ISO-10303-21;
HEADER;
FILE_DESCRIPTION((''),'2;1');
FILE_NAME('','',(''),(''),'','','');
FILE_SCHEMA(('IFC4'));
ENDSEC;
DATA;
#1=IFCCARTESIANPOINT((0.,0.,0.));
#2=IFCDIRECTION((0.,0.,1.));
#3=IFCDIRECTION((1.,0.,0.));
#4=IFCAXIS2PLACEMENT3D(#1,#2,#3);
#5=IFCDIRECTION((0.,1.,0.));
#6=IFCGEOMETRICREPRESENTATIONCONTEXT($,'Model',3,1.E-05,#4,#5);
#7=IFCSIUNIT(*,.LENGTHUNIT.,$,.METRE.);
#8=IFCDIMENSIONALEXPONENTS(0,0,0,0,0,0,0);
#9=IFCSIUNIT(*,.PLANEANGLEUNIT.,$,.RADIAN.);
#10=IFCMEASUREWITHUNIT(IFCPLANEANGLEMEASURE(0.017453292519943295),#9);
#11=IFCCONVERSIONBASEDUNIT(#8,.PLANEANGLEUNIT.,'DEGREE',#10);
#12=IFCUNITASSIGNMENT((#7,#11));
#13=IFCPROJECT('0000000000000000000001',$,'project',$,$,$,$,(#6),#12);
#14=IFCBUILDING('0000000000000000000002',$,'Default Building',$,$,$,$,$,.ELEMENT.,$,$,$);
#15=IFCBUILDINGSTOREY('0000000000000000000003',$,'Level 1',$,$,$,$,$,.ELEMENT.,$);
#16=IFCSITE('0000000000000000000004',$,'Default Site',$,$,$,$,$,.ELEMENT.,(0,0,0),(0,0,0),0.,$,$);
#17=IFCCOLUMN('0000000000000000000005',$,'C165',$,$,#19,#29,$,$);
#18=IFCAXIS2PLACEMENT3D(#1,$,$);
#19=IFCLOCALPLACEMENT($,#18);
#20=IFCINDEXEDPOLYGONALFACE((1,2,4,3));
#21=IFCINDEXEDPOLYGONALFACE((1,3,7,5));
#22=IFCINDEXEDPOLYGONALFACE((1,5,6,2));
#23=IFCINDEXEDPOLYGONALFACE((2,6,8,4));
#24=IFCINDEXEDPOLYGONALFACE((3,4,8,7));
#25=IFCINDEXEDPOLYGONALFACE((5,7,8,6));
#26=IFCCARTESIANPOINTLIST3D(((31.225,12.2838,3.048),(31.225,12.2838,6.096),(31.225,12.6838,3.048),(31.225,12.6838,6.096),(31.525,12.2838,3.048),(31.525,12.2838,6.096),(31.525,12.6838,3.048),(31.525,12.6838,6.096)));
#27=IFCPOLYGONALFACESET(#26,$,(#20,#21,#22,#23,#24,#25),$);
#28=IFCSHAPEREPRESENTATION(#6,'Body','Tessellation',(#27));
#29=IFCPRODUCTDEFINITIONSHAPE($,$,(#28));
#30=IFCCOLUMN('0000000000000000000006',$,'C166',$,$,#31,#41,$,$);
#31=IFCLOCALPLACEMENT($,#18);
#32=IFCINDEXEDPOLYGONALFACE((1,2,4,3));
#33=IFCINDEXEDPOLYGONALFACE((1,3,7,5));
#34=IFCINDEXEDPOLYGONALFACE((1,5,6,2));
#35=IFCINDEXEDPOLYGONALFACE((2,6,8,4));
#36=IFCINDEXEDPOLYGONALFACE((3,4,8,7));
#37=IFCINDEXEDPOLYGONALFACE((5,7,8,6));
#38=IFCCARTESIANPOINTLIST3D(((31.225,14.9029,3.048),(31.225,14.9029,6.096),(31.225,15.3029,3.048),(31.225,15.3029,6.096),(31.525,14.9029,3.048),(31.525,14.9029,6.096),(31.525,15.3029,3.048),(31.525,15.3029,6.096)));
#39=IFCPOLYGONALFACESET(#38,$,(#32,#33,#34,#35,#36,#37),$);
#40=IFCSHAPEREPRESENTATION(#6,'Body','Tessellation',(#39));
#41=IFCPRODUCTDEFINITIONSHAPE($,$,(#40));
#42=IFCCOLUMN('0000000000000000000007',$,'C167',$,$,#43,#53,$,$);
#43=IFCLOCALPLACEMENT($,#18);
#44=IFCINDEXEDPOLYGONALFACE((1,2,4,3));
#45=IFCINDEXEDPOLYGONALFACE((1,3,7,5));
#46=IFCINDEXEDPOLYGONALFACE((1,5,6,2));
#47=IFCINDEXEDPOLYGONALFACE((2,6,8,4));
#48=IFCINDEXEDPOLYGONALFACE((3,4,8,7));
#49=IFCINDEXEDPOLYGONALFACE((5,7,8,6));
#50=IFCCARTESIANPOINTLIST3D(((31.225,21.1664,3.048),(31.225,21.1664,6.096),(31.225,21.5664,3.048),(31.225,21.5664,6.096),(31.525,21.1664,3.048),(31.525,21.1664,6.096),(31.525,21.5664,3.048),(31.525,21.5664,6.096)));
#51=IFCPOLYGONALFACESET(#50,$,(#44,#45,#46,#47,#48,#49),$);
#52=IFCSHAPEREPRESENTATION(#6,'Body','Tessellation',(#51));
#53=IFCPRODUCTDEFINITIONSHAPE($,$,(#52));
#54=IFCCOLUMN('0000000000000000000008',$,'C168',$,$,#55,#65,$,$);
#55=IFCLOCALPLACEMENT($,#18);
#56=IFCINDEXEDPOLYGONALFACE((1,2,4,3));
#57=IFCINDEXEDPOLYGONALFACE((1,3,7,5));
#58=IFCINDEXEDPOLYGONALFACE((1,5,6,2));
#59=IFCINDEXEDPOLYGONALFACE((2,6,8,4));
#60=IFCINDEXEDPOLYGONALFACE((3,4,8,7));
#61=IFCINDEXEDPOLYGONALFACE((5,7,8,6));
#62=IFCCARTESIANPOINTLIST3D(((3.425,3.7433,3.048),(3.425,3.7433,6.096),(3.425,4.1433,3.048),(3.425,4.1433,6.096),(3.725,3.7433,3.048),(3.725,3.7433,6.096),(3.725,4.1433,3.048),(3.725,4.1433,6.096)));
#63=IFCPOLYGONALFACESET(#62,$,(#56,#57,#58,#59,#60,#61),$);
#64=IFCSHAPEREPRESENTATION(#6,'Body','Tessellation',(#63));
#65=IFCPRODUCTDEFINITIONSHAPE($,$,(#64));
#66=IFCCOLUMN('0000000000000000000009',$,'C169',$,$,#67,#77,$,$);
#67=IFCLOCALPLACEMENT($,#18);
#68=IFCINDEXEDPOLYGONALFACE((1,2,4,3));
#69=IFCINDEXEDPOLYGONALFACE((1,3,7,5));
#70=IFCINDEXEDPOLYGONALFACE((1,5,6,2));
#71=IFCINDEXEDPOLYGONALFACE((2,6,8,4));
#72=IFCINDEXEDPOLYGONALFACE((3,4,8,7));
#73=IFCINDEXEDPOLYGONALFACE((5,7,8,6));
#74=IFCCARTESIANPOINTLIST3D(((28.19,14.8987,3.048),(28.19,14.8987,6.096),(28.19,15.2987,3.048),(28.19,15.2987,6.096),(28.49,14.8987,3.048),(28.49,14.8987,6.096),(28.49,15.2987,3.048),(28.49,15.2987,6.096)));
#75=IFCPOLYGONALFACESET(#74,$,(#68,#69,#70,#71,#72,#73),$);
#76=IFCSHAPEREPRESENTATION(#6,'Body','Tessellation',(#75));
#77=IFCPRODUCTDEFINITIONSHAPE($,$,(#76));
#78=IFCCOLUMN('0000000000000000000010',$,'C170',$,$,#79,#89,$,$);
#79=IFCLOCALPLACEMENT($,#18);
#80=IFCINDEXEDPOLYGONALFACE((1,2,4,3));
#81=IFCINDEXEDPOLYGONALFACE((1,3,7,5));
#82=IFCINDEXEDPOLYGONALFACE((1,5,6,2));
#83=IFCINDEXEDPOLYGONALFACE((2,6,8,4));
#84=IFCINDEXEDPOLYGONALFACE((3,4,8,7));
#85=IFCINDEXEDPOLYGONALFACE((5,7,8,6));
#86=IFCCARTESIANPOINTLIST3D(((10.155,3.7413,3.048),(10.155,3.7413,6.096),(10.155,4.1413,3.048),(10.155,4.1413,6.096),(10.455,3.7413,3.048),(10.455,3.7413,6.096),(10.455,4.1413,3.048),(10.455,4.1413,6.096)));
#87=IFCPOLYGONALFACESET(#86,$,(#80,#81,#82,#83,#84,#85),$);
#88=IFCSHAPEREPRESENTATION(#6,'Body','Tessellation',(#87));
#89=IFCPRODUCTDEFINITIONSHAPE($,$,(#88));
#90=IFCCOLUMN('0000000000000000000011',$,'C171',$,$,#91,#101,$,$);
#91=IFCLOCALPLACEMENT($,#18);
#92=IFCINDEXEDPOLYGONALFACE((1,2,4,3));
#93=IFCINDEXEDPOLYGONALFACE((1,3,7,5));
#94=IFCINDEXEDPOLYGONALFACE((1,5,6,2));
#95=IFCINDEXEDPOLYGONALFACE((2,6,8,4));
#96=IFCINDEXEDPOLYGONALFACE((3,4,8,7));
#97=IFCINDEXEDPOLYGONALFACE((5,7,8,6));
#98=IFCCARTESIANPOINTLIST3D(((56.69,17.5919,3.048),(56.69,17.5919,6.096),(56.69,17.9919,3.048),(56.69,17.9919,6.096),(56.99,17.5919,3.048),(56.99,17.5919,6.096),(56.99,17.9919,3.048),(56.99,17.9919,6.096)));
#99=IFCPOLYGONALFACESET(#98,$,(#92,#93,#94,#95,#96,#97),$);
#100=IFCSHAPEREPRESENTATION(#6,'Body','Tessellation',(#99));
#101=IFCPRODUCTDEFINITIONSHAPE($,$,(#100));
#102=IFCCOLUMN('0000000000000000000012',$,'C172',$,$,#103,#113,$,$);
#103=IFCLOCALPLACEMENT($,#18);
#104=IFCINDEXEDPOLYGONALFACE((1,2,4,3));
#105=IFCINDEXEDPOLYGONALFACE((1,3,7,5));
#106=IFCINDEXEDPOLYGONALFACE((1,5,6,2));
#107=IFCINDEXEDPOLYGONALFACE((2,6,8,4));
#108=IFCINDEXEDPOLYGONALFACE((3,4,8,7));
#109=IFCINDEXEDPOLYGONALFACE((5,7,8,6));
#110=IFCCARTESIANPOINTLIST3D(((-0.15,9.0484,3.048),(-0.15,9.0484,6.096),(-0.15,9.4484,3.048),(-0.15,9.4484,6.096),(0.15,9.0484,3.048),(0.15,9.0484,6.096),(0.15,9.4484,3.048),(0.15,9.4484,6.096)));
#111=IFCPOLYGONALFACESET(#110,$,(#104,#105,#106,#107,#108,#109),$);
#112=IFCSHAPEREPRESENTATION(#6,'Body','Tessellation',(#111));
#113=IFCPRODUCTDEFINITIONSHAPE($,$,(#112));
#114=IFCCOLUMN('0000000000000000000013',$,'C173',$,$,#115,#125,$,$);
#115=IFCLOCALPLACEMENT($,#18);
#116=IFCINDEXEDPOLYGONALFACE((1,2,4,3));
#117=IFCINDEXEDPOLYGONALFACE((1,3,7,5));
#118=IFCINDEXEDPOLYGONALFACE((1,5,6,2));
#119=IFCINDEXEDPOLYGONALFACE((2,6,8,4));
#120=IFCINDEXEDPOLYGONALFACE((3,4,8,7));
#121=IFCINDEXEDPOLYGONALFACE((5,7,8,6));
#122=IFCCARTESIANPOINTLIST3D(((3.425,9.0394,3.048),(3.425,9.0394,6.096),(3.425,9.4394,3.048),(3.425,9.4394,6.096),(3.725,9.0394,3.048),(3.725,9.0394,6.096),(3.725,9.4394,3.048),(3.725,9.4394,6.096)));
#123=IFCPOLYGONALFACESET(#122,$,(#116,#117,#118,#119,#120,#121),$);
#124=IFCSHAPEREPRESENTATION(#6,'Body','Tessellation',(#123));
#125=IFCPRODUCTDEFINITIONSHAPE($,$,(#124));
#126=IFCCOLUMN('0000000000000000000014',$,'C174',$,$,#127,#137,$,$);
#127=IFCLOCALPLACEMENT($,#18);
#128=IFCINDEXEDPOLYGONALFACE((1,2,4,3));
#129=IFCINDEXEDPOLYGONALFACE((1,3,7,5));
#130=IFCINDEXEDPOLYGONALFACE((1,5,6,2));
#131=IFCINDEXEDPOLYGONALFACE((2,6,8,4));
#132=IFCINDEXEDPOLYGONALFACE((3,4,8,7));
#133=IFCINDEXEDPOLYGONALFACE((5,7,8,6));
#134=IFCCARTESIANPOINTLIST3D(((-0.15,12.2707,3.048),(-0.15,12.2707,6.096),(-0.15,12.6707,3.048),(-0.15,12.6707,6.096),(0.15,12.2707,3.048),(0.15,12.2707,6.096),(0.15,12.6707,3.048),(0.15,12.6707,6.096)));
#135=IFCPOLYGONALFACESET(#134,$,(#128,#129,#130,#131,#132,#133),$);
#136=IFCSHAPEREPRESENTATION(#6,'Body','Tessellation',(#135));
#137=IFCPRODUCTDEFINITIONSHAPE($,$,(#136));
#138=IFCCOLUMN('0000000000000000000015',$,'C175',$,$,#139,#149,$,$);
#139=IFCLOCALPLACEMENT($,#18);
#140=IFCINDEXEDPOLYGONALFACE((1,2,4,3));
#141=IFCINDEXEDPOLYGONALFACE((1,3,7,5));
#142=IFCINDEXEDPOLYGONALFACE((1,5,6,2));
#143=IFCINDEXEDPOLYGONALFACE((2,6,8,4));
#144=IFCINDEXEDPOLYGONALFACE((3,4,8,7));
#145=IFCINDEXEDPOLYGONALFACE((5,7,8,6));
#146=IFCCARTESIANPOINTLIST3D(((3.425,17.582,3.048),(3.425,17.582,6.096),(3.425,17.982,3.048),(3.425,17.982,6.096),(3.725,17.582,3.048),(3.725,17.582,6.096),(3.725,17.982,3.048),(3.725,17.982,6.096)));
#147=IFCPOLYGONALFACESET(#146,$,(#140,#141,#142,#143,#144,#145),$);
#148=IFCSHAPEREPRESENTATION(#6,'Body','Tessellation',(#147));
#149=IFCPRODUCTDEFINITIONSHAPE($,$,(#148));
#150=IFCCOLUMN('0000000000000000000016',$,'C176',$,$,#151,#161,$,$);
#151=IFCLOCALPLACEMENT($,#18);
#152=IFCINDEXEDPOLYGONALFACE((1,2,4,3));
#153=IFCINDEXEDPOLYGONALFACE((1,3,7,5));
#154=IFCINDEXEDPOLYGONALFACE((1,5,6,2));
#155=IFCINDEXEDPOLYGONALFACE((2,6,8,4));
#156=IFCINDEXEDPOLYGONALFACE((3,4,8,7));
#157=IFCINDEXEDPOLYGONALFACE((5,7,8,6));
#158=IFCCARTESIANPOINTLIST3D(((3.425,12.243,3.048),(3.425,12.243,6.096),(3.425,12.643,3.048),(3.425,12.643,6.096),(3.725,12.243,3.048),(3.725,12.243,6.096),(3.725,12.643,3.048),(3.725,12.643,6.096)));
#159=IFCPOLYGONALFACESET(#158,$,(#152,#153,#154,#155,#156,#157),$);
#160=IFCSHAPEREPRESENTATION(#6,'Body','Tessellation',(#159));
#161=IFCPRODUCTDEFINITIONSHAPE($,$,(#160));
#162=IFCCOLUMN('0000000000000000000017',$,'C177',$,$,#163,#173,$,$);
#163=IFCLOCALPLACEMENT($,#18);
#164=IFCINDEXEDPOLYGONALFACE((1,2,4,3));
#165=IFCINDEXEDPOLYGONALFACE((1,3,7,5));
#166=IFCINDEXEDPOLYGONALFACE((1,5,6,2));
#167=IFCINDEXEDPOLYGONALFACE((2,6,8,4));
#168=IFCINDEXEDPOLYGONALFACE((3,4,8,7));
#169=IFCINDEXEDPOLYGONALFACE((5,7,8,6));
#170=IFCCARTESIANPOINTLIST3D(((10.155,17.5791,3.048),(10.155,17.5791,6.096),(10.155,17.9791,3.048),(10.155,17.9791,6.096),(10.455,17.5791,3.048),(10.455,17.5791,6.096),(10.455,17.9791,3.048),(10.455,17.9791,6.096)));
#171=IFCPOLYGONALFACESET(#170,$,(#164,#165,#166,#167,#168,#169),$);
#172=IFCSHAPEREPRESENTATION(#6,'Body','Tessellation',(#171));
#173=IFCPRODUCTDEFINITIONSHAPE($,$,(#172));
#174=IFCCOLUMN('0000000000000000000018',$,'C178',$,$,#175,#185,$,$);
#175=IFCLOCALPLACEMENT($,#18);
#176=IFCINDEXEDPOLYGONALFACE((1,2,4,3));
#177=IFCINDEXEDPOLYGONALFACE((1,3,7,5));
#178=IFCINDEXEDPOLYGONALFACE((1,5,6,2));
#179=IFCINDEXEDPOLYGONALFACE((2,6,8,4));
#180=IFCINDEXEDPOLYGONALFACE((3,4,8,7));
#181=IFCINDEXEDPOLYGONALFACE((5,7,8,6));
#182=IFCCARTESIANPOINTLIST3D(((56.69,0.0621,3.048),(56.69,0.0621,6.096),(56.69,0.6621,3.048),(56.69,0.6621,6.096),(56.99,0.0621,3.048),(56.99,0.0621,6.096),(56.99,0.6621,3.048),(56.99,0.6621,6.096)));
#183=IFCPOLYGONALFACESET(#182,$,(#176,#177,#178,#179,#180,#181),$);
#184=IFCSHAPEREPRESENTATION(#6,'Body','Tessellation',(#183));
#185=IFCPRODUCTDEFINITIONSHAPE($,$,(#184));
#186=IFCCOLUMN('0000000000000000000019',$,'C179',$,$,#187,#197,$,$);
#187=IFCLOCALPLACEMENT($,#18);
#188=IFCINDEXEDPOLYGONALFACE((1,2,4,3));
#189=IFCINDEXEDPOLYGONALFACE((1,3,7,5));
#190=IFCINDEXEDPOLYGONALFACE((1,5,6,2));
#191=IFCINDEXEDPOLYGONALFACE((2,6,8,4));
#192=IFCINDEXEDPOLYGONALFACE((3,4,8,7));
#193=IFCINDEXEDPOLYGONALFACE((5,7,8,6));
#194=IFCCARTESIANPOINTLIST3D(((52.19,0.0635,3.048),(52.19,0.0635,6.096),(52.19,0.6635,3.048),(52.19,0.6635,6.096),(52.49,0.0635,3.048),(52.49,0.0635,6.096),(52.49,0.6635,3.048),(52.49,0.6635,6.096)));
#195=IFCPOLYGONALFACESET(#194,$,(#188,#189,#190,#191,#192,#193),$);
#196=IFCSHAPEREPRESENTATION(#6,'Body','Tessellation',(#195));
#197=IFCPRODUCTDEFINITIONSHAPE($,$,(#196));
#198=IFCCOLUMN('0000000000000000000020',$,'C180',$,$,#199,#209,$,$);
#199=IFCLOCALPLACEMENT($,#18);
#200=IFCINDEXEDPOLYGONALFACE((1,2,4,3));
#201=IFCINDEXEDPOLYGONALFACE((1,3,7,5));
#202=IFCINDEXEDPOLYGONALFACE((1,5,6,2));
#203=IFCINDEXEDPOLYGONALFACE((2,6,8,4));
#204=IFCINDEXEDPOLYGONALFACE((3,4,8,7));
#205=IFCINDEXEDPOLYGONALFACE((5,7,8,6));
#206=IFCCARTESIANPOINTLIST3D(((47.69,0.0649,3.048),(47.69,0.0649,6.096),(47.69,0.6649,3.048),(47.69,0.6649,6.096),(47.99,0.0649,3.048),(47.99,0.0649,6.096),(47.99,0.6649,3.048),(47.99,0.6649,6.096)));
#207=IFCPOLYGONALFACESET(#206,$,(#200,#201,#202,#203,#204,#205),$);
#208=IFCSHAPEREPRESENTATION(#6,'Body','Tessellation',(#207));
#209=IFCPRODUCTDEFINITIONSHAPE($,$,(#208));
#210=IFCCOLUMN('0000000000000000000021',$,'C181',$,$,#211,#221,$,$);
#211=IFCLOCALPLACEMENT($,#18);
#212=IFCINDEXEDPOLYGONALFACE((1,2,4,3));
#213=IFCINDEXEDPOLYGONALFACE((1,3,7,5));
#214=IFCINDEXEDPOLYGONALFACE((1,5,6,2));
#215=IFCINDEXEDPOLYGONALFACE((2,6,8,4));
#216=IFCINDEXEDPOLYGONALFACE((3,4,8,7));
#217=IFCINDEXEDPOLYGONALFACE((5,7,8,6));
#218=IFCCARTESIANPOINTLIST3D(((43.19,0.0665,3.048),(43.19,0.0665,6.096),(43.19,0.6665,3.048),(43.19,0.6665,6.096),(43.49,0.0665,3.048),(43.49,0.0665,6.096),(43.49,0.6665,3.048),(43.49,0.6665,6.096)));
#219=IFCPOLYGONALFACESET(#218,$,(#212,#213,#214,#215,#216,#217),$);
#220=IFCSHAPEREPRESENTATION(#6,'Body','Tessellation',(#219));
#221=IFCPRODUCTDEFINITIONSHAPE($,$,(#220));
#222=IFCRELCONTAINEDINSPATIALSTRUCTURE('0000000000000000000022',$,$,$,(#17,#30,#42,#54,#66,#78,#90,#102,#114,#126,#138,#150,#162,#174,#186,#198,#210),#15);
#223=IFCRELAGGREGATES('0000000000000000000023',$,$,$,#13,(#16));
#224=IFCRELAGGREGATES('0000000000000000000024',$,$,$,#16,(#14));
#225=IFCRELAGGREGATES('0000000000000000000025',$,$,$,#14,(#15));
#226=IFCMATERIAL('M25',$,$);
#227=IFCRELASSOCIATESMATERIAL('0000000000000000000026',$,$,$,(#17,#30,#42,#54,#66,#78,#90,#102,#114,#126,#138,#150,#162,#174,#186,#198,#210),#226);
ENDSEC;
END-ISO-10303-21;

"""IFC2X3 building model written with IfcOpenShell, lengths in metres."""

from ifc_helpers import new_model, entity, si_unit, converted_unit, direction, frame, frame_2d, origin_with_axes, place, context, project, spatial, rectangle, extrude, material, element, save


model = new_model("IFC2X3")

# Units and contexts
model_context = context("Model", 3, precision=1e-05, world=origin_with_axes(), true_north=direction((0.0, 1.0, 0.0)))
ifc_project = project(units=[si_unit("LENGTHUNIT", "METRE"), converted_unit("PLANEANGLEUNIT", "DEGREE", entity("IfcPlaneAngleMeasure", 0.017453292519943295), si_unit("PLANEANGLEUNIT", "RADIAN"), dimensions=[0, 0, 0, 0, 0, 0, 0])], contexts=[model_context])

# Site, building, storey
site = spatial("IfcSite", under=ifc_project, Name="Default Site", CompositionType="ELEMENT", RefLatitude=(0, 0, 0), RefLongitude=(0, 0, 0), RefElevation=0.0)
building = spatial("IfcBuilding", under=site, Name="Default Building", CompositionType="ELEMENT")
storey = spatial("IfcBuildingStorey", under=building, Name="Level 1", CompositionType="ELEMENT")

# Columns
ifc_material = material(Name="M25")
placement = place(None, origin_with_axes())
element("IfcColumn", 1, at=placement, inside=storey, material=ifc_material, Name="C165", context=model_context, shape_type="SweptSolid", body=[
    extrude(rectangle(XDim=0.3, YDim=0.4, at=frame_2d((0.0, 0.0), x_axis=(1.0, 0.0, 0.0))), frame((31.375, 12.4838, 3.048), z_axis=(0.0, 0.0, 1.0), x_axis=(1.0, 0.0, 0.0)), (0.0, 0.0, 1.0), 3.048),
])
element("IfcColumn", 2, at=placement, inside=storey, material=ifc_material, Name="C166", context=model_context, shape_type="SweptSolid", body=[
    extrude(rectangle(XDim=0.3, YDim=0.4, at=frame_2d((0.0, 0.0), x_axis=(1.0, 0.0, 0.0))), frame((31.375, 15.1029, 3.048), z_axis=(0.0, 0.0, 1.0), x_axis=(1.0, 0.0, 0.0)), (0.0, 0.0, 1.0), 3.048),
])
element("IfcColumn", 3, at=placement, inside=storey, material=ifc_material, Name="C167", context=model_context, shape_type="SweptSolid", body=[
    extrude(rectangle(XDim=0.3, YDim=0.4, at=frame_2d((0.0, 0.0), x_axis=(1.0, 0.0, 0.0))), frame((31.375, 21.3664, 3.048), z_axis=(0.0, 0.0, 1.0), x_axis=(1.0, 0.0, 0.0)), (0.0, 0.0, 1.0), 3.048),
])
element("IfcColumn", 4, at=placement, inside=storey, material=ifc_material, Name="C168", context=model_context, shape_type="SweptSolid", body=[
    extrude(rectangle(XDim=0.3, YDim=0.4, at=frame_2d((0.0, 0.0), x_axis=(1.0, 0.0, 0.0))), frame((3.575, 3.9433, 3.048), z_axis=(0.0, 0.0, 1.0), x_axis=(1.0, 0.0, 0.0)), (0.0, 0.0, 1.0), 3.048),
])
element("IfcColumn", 5, at=placement, inside=storey, material=ifc_material, Name="C169", context=model_context, shape_type="SweptSolid", body=[
    extrude(rectangle(XDim=0.3, YDim=0.4, at=frame_2d((0.0, 0.0), x_axis=(1.0, 0.0, 0.0))), frame((28.34, 15.0987, 3.048), z_axis=(0.0, 0.0, 1.0), x_axis=(1.0, 0.0, 0.0)), (0.0, 0.0, 1.0), 3.048),
])
element("IfcColumn", 6, at=placement, inside=storey, material=ifc_material, Name="C170", context=model_context, shape_type="SweptSolid", body=[
    extrude(rectangle(XDim=0.3, YDim=0.4, at=frame_2d((0.0, 0.0), x_axis=(1.0, 0.0, 0.0))), frame((10.305, 3.9413, 3.048), z_axis=(0.0, 0.0, 1.0), x_axis=(1.0, 0.0, 0.0)), (0.0, 0.0, 1.0), 3.048),
])
element("IfcColumn", 7, at=placement, inside=storey, material=ifc_material, Name="C171", context=model_context, shape_type="SweptSolid", body=[
    extrude(rectangle(XDim=0.3, YDim=0.4, at=frame_2d((0.0, 0.0), x_axis=(1.0, 0.0, 0.0))), frame((56.84, 17.7919, 3.048), z_axis=(0.0, 0.0, 1.0), x_axis=(1.0, 0.0, 0.0)), (0.0, 0.0, 1.0), 3.048),
])
element("IfcColumn", 8, at=placement, inside=storey, material=ifc_material, Name="C172", context=model_context, shape_type="SweptSolid", body=[
    extrude(rectangle(XDim=0.3, YDim=0.4, at=frame_2d((0.0, 0.0), x_axis=(1.0, 0.0, 0.0))), frame((0.0, 9.2484, 3.048), z_axis=(0.0, 0.0, 1.0), x_axis=(1.0, 0.0, 0.0)), (0.0, 0.0, 1.0), 3.048),
])
element("IfcColumn", 9, at=placement, inside=storey, material=ifc_material, Name="C173", context=model_context, shape_type="SweptSolid", body=[
    extrude(rectangle(XDim=0.3, YDim=0.4, at=frame_2d((0.0, 0.0), x_axis=(1.0, 0.0, 0.0))), frame((3.575, 9.2394, 3.048), z_axis=(0.0, 0.0, 1.0), x_axis=(1.0, 0.0, 0.0)), (0.0, 0.0, 1.0), 3.048),
])
element("IfcColumn", 10, at=placement, inside=storey, material=ifc_material, Name="C174", context=model_context, shape_type="SweptSolid", body=[
    extrude(rectangle(XDim=0.3, YDim=0.4, at=frame_2d((0.0, 0.0), x_axis=(1.0, 0.0, 0.0))), frame((0.0, 12.4707, 3.048), z_axis=(0.0, 0.0, 1.0), x_axis=(1.0, 0.0, 0.0)), (0.0, 0.0, 1.0), 3.048),
])
element("IfcColumn", 11, at=placement, inside=storey, material=ifc_material, Name="C175", context=model_context, shape_type="SweptSolid", body=[
    extrude(rectangle(XDim=0.3, YDim=0.4, at=frame_2d((0.0, 0.0), x_axis=(1.0, 0.0, 0.0))), frame((3.575, 17.782, 3.048), z_axis=(0.0, 0.0, 1.0), x_axis=(1.0, 0.0, 0.0)), (0.0, 0.0, 1.0), 3.048),
])
element("IfcColumn", 12, at=placement, inside=storey, material=ifc_material, Name="C176", context=model_context, shape_type="SweptSolid", body=[
    extrude(rectangle(XDim=0.3, YDim=0.4, at=frame_2d((0.0, 0.0), x_axis=(1.0, 0.0, 0.0))), frame((3.575, 12.443, 3.048), z_axis=(0.0, 0.0, 1.0), x_axis=(1.0, 0.0, 0.0)), (0.0, 0.0, 1.0), 3.048),
])
element("IfcColumn", 13, at=placement, inside=storey, material=ifc_material, Name="C177", context=model_context, shape_type="SweptSolid", body=[
    extrude(rectangle(XDim=0.3, YDim=0.4, at=frame_2d((0.0, 0.0), x_axis=(1.0, 0.0, 0.0))), frame((10.305, 17.7791, 3.048), z_axis=(0.0, 0.0, 1.0), x_axis=(1.0, 0.0, 0.0)), (0.0, 0.0, 1.0), 3.048),
])
element("IfcColumn", 14, at=placement, inside=storey, material=ifc_material, Name="C178", context=model_context, shape_type="SweptSolid", body=[
    extrude(rectangle(XDim=0.3, YDim=0.6, at=frame_2d((0.0, 0.0), x_axis=(1.0, 0.0, 0.0))), frame((56.84, 0.3621, 3.048), z_axis=(0.0, 0.0, 1.0), x_axis=(1.0, 0.0, 0.0)), (0.0, 0.0, 1.0), 3.048),
])
element("IfcColumn", 15, at=placement, inside=storey, material=ifc_material, Name="C179", context=model_context, shape_type="SweptSolid", body=[
    extrude(rectangle(XDim=0.3, YDim=0.6, at=frame_2d((0.0, 0.0), x_axis=(1.0, 0.0, 0.0))), frame((52.34, 0.3635, 3.048), z_axis=(0.0, 0.0, 1.0), x_axis=(1.0, 0.0, 0.0)), (0.0, 0.0, 1.0), 3.048),
])
element("IfcColumn", 16, at=placement, inside=storey, material=ifc_material, Name="C180", context=model_context, shape_type="SweptSolid", body=[
    extrude(rectangle(XDim=0.3, YDim=0.6, at=frame_2d((0.0, 0.0), x_axis=(1.0, 0.0, 0.0))), frame((47.84, 0.3649, 3.048), z_axis=(0.0, 0.0, 1.0), x_axis=(1.0, 0.0, 0.0)), (0.0, 0.0, 1.0), 3.048),
])
element("IfcColumn", 17, at=placement, inside=storey, material=ifc_material, Name="C181", context=model_context, shape_type="SweptSolid", body=[
    extrude(rectangle(XDim=0.3, YDim=0.6, at=frame_2d((0.0, 0.0), x_axis=(1.0, 0.0, 0.0))), frame((43.34, 0.3665, 3.048), z_axis=(0.0, 0.0, 1.0), x_axis=(1.0, 0.0, 0.0)), (0.0, 0.0, 1.0), 3.048),
])

save(model, "model.ifc")
